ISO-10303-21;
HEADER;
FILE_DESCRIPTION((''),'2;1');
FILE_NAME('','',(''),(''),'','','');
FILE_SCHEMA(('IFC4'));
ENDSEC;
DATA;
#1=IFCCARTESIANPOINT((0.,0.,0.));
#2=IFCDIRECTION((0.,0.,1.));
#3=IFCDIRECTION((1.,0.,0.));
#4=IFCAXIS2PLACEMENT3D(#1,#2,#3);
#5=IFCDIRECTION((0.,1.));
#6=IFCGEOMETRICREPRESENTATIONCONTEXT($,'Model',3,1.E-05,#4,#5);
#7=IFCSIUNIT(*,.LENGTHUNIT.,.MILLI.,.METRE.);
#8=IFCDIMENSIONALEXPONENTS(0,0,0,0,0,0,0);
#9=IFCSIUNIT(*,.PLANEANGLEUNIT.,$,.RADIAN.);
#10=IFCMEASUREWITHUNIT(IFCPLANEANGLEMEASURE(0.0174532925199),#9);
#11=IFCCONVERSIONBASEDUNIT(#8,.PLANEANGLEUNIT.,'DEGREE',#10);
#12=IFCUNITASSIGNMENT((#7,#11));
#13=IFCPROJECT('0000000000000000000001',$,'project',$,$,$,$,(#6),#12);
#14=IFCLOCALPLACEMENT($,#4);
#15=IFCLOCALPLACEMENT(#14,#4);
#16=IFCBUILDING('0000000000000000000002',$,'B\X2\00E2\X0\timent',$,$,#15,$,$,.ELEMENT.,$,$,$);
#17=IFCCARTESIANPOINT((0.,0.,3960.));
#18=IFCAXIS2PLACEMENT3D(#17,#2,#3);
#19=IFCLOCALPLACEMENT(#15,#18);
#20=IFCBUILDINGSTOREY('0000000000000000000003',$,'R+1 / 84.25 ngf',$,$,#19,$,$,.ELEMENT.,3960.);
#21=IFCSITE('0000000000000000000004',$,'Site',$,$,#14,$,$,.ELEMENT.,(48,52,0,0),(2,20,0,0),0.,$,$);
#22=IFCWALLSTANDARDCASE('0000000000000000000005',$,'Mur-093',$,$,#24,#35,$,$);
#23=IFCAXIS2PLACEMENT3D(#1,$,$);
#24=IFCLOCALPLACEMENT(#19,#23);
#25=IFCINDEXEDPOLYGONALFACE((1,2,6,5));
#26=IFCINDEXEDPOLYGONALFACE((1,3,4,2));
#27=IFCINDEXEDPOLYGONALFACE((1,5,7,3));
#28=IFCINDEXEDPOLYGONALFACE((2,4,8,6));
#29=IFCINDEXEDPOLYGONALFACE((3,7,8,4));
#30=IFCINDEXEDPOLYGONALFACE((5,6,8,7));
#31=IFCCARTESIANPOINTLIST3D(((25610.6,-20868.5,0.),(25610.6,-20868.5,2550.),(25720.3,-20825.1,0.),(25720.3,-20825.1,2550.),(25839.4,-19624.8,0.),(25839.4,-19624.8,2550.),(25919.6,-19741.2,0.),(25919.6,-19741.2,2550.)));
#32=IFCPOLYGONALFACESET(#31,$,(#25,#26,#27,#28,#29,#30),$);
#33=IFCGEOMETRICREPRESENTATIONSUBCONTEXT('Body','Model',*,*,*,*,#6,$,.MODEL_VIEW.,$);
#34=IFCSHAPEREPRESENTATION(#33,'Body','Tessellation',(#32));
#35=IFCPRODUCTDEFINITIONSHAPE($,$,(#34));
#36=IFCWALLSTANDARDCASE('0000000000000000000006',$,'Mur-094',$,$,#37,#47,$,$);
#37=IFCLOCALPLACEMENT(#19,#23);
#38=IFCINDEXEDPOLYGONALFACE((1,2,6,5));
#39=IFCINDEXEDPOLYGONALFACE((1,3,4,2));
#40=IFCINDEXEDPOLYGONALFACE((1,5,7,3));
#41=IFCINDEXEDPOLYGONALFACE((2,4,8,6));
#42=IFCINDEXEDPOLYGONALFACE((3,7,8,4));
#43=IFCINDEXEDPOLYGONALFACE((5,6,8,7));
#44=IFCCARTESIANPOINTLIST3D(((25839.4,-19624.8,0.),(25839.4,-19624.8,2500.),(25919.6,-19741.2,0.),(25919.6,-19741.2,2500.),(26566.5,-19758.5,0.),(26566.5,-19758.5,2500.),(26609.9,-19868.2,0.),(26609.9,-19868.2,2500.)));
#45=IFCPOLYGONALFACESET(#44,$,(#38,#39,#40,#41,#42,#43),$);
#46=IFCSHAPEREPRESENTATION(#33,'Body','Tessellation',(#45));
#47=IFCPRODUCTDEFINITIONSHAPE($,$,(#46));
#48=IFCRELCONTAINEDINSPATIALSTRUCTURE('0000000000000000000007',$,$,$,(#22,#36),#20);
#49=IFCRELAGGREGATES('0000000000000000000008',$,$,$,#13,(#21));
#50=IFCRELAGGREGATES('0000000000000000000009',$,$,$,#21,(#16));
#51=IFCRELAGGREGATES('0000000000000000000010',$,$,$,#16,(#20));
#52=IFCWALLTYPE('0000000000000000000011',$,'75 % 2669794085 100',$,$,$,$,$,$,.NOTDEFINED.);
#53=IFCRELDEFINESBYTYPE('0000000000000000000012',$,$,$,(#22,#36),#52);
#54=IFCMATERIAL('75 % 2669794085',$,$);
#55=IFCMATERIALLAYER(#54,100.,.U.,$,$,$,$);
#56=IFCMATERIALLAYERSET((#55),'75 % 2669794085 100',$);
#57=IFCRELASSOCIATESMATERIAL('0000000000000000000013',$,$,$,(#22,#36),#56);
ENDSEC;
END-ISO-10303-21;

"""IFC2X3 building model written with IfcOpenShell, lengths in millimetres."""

from ifc_helpers import new_model, entity, si_unit, converted_unit, direction, frame, origin_with_axes, place, context, subcontext, project, spatial, polyline, outline, extrude, material, layer, layer_set, layer_usage, type_object, element, save


model = new_model("IFC2X3")

# Units and contexts
model_context = context("Model", 3, precision=1e-05, world=origin_with_axes(), true_north=direction((0.0, 1.0)))
body_context = subcontext(model_context, "Body", "Model", "MODEL_VIEW")
ifc_project = project(units=[si_unit("LENGTHUNIT", "METRE", prefix="MILLI"), converted_unit("PLANEANGLEUNIT", "DEGREE", entity("IfcPlaneAngleMeasure", 0.0174532925199), si_unit("PLANEANGLEUNIT", "RADIAN"), dimensions=[0, 0, 0, 0, 0, 0, 0])], contexts=[model_context])

# Site, building, storey
site_placement = place(None, origin_with_axes())
site = spatial("IfcSite", under=ifc_project, at=site_placement, Name="Site", CompositionType="ELEMENT", RefLatitude=(48, 52, 0, 0), RefLongitude=(2, 20, 0, 0), RefElevation=0.0)
building_placement = place(site_placement, origin_with_axes())
building = spatial("IfcBuilding", under=site, at=building_placement, Name="Bâtiment", CompositionType="ELEMENT")
storey_placement = place(building_placement, frame((0.0, 0.0, 3960.0), z_axis=(0.0, 0.0, 1.0), x_axis=(1.0, 0.0, 0.0)))
storey = spatial("IfcBuildingStorey", under=building, at=storey_placement, Name="R+1 / 84.25 ngf", CompositionType="ELEMENT", Elevation=3960.0)

# Shared definitions
ifc_material_1 = material(Name="75 % 2669794085")

# Shared definitions
ifc_layer_1 = layer(ifc_material_1, 100.0, ventilated="UNKNOWN")
ifc_layer_set_1 = layer_set([ifc_layer_1], Name="75 % 2669794085 100")
wall_type_1 = type_object("IfcWallType", Name="75 % 2669794085 100", PredefinedType="NOTDEFINED")

# Walls
ifc_layer_usage_1 = layer_usage(ifc_layer_set_1, "AXIS2", "NEGATIVE", 0.0)
wall_1_placement = place(storey_placement, frame((25919.6, -19741.2, 0.0), z_axis=(0.0, 0.0, 1.0), x_axis=(-0.180879, -0.983505, 0.0)))
element("IfcWallStandardCase", 1, at=wall_1_placement, inside=storey, type_object=wall_type_1, material=ifc_layer_usage_1, Name="Mur-093", context=body_context, shape_type="SweptSolid", body=[
    extrude(outline(polyline([(-100.0, -100.0), (1164.6, -100.0), (1102.1, 0.0), (0.0, 0.0), (-100.0, -100.0)])), origin_with_axes(), (0.0, 0.0, 1.0), 2550.0),
])
ifc_layer_usage_2 = layer_usage(ifc_layer_set_1, "AXIS2", "POSITIVE", 0.0)
wall_2_placement = place(storey_placement, frame((25919.6, -19741.2, 0.0), z_axis=(0.0, 0.0, 1.0), x_axis=(0.983505, -0.180879, 0.0)))
element("IfcWallStandardCase", 2, at=wall_2_placement, inside=storey, type_object=wall_type_1, material=ifc_layer_usage_2, Name="Mur-094", context=body_context, shape_type="SweptSolid", body=[
    extrude(outline(polyline([(0.0, 0.0), (701.9, 0.0), (639.4, 100.0), (-100.0, 100.0), (0.0, 0.0)])), origin_with_axes(), (0.0, 0.0, 1.0), 2500.0),
])

save(model, "model.ifc")
